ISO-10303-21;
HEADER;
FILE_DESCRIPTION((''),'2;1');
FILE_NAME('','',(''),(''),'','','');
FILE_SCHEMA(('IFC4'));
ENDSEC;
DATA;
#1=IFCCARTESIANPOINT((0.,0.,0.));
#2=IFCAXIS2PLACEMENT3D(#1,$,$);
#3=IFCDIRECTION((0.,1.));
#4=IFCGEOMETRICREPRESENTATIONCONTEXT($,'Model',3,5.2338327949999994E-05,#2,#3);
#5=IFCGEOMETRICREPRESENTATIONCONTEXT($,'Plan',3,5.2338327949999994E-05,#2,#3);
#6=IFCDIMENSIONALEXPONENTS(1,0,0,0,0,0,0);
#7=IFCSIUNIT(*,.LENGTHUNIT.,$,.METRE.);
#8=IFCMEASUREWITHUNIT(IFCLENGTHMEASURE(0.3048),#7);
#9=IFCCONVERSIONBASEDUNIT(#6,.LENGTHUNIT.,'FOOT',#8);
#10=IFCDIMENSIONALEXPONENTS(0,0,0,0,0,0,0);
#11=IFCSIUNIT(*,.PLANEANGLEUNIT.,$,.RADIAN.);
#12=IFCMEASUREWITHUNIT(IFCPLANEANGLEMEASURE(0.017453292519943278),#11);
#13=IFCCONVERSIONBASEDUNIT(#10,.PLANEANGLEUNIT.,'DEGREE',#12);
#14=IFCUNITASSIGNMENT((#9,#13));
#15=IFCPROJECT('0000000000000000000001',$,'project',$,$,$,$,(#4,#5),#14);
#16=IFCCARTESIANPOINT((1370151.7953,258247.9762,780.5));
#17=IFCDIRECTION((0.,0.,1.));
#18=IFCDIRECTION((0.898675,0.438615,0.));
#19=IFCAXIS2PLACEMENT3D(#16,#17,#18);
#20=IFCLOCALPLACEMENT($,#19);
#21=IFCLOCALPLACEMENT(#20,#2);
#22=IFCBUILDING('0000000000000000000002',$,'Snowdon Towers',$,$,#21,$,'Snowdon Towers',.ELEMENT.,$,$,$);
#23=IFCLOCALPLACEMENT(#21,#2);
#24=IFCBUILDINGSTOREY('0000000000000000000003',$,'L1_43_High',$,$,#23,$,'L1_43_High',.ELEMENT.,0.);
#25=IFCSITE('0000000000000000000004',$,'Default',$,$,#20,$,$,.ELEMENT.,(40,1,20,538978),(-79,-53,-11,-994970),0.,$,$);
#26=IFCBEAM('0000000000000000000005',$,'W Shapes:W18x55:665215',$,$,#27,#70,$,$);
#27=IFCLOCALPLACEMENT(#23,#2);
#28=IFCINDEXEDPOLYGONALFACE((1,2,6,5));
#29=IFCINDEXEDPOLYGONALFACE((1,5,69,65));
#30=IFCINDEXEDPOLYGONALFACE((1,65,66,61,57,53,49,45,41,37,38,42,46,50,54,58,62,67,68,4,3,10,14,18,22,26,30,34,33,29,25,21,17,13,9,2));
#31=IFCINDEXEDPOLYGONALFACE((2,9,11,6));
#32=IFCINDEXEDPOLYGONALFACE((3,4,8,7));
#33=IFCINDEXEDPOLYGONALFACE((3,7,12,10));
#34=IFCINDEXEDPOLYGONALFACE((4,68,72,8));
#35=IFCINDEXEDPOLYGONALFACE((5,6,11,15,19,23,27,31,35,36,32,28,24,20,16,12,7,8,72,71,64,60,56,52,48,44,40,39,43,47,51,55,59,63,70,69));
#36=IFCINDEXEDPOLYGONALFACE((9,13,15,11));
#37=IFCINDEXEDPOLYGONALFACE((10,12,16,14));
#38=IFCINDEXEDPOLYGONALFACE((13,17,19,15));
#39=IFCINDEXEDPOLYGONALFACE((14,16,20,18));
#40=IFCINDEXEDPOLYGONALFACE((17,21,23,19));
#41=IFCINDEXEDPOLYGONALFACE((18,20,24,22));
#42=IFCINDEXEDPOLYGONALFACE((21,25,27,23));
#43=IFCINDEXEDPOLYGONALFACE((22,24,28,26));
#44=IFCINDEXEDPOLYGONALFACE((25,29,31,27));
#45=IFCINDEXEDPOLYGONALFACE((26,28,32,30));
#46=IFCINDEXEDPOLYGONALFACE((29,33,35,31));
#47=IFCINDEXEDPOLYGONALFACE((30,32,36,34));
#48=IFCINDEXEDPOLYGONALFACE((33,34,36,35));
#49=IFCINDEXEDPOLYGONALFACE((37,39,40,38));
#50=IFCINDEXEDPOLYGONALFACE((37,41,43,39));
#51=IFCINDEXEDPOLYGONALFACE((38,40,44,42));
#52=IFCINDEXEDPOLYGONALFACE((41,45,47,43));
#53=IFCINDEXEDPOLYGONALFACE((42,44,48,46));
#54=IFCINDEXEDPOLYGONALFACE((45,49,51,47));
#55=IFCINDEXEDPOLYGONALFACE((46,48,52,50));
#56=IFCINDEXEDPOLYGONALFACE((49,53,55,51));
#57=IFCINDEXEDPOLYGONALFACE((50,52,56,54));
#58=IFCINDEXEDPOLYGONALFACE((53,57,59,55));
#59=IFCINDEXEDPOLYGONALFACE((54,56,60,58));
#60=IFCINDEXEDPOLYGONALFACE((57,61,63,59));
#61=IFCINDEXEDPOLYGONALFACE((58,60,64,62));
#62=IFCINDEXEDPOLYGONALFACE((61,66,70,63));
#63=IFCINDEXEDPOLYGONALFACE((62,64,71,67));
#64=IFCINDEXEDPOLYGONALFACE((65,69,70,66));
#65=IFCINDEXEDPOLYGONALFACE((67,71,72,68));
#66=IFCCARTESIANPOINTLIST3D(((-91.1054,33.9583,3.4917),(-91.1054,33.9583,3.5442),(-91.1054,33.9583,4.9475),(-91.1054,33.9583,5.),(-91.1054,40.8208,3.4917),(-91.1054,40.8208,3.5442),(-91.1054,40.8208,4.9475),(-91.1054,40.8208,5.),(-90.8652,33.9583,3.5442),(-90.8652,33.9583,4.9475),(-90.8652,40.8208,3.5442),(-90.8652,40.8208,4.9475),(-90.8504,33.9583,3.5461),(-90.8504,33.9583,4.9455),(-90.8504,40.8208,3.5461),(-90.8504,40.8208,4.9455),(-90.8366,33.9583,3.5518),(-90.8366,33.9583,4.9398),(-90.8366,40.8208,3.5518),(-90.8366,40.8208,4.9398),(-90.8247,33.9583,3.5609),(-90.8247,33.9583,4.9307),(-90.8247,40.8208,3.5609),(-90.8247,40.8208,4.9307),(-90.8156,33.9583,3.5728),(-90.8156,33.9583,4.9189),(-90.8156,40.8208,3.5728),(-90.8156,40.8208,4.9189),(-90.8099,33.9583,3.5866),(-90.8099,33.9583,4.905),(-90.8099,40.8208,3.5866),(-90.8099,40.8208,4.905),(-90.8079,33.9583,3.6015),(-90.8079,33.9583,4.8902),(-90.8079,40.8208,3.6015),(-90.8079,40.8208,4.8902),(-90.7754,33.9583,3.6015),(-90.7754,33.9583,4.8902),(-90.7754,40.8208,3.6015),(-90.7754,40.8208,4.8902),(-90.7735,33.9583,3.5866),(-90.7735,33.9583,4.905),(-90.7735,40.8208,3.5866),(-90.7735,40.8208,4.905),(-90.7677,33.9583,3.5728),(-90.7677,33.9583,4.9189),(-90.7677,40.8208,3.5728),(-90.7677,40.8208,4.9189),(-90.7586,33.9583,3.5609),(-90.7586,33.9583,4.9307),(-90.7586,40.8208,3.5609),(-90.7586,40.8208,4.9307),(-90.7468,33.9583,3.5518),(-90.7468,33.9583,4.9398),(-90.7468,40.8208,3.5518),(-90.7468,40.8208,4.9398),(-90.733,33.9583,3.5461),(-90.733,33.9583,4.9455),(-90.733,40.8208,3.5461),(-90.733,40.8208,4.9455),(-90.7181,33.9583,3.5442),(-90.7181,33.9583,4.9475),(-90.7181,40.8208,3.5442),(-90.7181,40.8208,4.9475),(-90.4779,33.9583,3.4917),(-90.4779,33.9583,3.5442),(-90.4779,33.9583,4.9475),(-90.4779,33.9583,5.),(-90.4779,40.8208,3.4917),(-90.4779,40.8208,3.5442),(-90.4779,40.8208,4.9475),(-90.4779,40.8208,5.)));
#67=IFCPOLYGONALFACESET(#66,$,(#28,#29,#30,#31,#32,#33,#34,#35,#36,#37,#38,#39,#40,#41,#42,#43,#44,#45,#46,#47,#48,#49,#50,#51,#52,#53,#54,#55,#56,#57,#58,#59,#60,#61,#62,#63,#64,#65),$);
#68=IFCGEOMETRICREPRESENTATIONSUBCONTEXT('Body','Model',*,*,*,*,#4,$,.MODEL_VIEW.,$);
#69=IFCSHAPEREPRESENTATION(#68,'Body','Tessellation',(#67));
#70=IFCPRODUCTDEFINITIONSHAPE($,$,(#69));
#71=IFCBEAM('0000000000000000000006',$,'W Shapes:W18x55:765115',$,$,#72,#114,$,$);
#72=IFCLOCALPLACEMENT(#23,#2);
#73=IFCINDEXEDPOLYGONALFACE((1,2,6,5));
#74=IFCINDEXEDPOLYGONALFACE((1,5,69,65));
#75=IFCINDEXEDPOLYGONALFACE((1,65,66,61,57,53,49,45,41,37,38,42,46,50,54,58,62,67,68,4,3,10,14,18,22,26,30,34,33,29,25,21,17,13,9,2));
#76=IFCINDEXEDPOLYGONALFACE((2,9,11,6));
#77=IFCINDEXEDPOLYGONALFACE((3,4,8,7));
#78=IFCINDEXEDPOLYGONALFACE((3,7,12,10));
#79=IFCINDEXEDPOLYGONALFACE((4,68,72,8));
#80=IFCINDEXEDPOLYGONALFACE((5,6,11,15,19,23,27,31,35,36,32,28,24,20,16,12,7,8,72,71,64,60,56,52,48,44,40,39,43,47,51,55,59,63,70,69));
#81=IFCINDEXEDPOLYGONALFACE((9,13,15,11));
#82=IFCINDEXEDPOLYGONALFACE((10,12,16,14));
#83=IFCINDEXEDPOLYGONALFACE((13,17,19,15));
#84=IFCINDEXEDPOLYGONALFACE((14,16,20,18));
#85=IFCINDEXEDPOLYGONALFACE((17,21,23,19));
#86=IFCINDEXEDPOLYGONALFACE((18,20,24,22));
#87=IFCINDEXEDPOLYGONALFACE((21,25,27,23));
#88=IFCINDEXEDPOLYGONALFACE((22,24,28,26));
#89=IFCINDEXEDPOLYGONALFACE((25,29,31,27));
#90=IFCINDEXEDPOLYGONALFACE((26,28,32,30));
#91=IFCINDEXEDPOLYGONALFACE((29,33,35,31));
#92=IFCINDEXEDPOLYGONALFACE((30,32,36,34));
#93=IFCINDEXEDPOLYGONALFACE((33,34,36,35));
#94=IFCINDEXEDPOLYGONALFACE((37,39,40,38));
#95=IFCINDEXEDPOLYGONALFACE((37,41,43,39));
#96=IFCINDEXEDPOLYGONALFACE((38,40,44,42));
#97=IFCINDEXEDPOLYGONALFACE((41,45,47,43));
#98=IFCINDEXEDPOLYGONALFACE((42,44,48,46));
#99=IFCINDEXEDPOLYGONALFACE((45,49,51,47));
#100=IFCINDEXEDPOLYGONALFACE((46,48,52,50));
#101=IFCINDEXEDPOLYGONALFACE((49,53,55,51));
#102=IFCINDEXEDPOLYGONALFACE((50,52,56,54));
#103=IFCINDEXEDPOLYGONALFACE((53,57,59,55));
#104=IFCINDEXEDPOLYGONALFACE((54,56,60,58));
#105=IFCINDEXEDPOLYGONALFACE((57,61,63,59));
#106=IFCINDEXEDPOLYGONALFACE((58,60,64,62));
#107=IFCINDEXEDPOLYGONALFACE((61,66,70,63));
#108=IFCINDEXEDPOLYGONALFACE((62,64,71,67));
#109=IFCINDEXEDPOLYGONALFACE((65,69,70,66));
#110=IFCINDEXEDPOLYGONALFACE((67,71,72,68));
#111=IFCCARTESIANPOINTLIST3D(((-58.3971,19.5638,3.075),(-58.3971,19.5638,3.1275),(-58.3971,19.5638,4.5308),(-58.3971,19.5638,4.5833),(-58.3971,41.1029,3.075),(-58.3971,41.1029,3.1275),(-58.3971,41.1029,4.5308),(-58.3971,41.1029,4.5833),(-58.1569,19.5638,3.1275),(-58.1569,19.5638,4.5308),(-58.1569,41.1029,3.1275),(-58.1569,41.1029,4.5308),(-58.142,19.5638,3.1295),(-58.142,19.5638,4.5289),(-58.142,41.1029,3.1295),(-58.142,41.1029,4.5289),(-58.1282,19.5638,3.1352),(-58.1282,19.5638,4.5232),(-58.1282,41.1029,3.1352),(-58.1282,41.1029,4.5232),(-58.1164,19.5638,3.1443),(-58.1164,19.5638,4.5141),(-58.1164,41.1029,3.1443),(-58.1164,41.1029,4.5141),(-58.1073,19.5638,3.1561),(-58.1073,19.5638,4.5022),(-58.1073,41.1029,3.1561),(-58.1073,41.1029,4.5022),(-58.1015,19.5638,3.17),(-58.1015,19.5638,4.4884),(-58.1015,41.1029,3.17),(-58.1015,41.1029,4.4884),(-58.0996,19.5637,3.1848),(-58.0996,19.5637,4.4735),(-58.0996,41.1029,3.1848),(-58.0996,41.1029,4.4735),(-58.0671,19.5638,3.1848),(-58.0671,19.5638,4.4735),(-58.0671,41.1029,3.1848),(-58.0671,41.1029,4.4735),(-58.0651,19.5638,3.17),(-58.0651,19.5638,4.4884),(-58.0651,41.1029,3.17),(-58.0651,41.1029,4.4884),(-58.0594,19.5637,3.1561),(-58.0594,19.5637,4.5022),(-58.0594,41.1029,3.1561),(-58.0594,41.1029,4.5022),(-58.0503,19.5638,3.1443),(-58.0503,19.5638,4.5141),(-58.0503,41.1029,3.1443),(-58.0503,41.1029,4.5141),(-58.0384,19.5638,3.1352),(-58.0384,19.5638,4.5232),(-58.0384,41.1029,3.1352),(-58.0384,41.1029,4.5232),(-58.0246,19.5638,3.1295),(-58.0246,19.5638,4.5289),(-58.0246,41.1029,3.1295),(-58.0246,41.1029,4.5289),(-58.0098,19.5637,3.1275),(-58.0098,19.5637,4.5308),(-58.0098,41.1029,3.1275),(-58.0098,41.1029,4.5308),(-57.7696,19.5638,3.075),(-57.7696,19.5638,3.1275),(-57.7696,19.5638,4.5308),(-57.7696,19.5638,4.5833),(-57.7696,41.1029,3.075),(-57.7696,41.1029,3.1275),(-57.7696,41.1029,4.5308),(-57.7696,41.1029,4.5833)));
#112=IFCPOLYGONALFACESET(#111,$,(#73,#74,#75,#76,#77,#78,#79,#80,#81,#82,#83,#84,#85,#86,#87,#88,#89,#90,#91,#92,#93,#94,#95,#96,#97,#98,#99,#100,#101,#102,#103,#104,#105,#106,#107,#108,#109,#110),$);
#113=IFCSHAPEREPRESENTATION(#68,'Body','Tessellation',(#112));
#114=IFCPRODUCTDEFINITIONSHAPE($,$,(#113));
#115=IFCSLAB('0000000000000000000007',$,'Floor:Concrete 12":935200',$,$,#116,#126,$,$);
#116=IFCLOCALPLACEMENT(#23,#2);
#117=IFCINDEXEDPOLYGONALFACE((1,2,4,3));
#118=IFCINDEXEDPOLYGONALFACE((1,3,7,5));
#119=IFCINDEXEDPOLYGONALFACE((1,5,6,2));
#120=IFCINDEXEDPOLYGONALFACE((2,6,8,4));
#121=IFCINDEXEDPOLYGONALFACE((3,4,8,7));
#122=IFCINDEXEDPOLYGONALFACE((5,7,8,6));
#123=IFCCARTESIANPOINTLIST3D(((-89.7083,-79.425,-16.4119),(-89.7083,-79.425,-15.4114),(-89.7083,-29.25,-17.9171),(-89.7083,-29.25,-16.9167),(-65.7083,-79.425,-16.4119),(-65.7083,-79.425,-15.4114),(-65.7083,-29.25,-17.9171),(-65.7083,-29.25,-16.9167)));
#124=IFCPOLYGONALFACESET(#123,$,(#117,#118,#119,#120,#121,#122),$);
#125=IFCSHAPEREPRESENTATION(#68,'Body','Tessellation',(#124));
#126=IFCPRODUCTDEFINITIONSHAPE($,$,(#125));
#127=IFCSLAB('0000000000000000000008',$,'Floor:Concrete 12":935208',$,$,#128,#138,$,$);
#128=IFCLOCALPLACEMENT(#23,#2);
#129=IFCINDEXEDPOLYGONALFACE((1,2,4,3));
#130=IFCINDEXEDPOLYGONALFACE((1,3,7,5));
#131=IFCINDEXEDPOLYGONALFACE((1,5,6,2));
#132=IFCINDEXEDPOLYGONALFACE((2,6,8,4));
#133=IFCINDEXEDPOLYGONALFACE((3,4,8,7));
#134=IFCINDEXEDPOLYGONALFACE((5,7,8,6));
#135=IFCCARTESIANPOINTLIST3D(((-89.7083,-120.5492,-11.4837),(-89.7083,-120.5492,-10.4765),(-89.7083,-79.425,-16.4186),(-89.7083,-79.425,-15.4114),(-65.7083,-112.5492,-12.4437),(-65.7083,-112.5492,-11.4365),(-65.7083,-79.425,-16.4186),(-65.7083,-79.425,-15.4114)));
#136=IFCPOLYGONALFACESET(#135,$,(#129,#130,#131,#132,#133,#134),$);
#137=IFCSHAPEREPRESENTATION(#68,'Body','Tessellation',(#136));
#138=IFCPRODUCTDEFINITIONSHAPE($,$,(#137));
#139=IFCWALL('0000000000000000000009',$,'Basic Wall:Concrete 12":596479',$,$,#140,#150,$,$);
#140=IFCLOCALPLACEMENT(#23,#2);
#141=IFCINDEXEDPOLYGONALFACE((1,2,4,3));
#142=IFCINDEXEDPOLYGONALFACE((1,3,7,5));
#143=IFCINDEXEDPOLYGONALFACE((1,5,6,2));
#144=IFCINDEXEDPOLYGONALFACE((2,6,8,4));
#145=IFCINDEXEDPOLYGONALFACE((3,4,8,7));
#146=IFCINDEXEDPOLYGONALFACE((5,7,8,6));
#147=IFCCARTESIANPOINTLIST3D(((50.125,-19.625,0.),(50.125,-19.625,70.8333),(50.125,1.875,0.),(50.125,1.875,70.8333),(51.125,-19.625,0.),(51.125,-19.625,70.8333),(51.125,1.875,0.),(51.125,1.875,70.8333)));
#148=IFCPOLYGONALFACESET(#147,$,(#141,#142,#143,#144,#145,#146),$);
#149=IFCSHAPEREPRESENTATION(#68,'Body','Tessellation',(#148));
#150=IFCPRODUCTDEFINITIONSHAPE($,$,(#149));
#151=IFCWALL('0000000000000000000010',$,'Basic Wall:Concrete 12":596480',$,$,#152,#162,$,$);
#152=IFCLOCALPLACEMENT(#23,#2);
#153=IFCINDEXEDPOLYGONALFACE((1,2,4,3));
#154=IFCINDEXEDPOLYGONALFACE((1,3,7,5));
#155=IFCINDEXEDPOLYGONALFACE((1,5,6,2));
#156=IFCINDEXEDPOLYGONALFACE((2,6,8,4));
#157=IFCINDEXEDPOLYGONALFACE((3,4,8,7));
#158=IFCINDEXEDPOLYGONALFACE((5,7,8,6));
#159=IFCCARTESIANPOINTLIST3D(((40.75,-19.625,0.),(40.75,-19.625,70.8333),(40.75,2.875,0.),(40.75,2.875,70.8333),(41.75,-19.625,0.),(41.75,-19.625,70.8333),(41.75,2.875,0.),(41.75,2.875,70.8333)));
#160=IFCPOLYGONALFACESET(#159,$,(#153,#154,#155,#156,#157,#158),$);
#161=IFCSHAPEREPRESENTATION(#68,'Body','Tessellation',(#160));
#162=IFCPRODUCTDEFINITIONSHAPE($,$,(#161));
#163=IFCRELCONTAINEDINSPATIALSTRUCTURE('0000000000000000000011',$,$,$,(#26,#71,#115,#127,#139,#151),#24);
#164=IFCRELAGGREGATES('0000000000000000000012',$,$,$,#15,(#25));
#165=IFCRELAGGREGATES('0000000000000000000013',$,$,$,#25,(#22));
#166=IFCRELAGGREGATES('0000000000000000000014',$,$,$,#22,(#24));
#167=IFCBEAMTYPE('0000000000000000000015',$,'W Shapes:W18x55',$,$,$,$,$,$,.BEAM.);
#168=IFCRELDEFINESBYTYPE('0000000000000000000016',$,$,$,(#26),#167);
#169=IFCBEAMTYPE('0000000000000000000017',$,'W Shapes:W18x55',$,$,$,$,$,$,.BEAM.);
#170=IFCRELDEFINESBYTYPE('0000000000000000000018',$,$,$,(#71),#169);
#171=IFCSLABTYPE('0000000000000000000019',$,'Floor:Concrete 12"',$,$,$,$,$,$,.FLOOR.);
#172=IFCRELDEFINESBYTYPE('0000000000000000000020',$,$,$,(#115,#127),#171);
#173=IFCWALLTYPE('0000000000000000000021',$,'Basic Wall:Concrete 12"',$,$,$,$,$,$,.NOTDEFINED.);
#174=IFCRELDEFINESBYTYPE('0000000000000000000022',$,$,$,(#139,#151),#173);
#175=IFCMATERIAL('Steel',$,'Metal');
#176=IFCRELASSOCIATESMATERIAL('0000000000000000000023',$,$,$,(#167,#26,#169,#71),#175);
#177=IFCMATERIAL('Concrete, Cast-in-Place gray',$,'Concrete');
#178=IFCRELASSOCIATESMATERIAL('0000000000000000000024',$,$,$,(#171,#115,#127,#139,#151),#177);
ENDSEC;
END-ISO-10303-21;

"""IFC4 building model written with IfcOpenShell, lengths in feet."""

from ifc_helpers import new_model, entity, si_unit, converted_unit, direction, frame, frame_2d, origin, place, context, subcontext, project, spatial, polyline, line, arc, indexed_curve, rectangle, outline, extrude, source, transform, mapped, material, type_object, type_shapes, element, save


model = new_model("IFC4")

# Units and contexts
model_context = context("Model", 3, precision=5.2338327949999994e-05, world=origin(), true_north=direction((0.0, 1.0)))
plan_context = context("Plan", 3, precision=5.2338327949999994e-05, world=origin(), true_north=direction((0.0, 1.0)))
body_context = subcontext(model_context, "Body", "Model", "MODEL_VIEW")
ifc_project = project(units=[converted_unit("LENGTHUNIT", "FOOT", entity("IfcLengthMeasure", 0.3048), si_unit("LENGTHUNIT", "METRE"), dimensions=[1, 0, 0, 0, 0, 0, 0]), converted_unit("PLANEANGLEUNIT", "DEGREE", entity("IfcPlaneAngleMeasure", 0.017453292519943278), si_unit("PLANEANGLEUNIT", "RADIAN"), dimensions=[0, 0, 0, 0, 0, 0, 0])], contexts=[model_context, plan_context])

# Site, building, storey
site_placement = place(None, frame((1370151.7953, 258247.9762, 780.5), z_axis=(0.0, 0.0, 1.0), x_axis=(0.898675, 0.438615, 0.0)))
site = spatial("IfcSite", under=ifc_project, at=site_placement, Name="Default", CompositionType="ELEMENT", RefLatitude=(40, 1, 20, 538978), RefLongitude=(-79, -53, -11, -994970), RefElevation=0.0)
building_placement = place(site_placement, origin())
building = spatial("IfcBuilding", under=site, at=building_placement, Name="Snowdon Towers", LongName="Snowdon Towers", CompositionType="ELEMENT")
storey_placement = place(building_placement, origin())
storey = spatial("IfcBuildingStorey", under=building, at=storey_placement, Name="L1_43_High", LongName="L1_43_High", CompositionType="ELEMENT", Elevation=0.0)

# Shared definitions
ifc_material_1 = material(Name="Steel", Category="Metal")

# Beams
ifc_material_2 = material(Name="Concrete, Cast-in-Place gray", Category="Concrete")
beam_type_1 = type_object("IfcBeamType", Name="W Shapes:W18x55", PredefinedType="BEAM", material=ifc_material_1)
shared_shape_1 = source(origin(), body_context, "Body", "SweptSolid", [
    extrude(outline(indexed_curve([(-0.7542, -0.3138), (-0.7017, -0.3138), (-0.7017, -0.0735), (-0.6849, -0.033), (-0.6444, -0.0162), (0.6444, -0.0162), (0.6849, -0.033), (0.7017, -0.0735), (0.7017, -0.3138), (0.7542, -0.3138), (0.7542, 0.3138), (0.7017, 0.3138), (0.7017, 0.0735), (0.6849, 0.033), (0.6444, 0.0163), (-0.6444, 0.0163), (-0.6849, 0.033), (-0.7017, 0.0735), (-0.7017, 0.3137), (-0.7542, 0.3137)], segments=[line(1, 2, 3), arc(3, 4, 5), line(5, 6), arc(6, 7, 8), line(8, 9, 10, 11, 12, 13), arc(13, 14, 15), line(15, 16), arc(16, 17, 18), line(18, 19, 20, 1)], self_intersect=False)), frame((-3.1125, 0.0, 0.0), z_axis=(1.0, 0.0, 0.0), x_axis=(0.0, 0.0, -1.0)), (0.0, 0.0, 1.0), 6.8625),
])
type_shapes(beam_type_1, [shared_shape_1])
beam_1_placement = place(storey_placement, frame((-90.7917, 37.7083, 4.2458), z_axis=(0.0, 0.0, 1.0), x_axis=(0.0, -1.0, 0.0)))
element("IfcBeam", 1, at=beam_1_placement, inside=storey, type_object=beam_type_1, material=ifc_material_1, Name="W Shapes:W18x55:665215", context=body_context, shape_type="MappedRepresentation", body=[
    mapped(shared_shape_1, transform((0.0, 0.0, 0.0), scale=1.0)),
])
beam_type_2 = type_object("IfcBeamType", Name="W Shapes:W18x55", PredefinedType="BEAM", material=ifc_material_1)
shared_shape_2 = source(origin(), body_context, "Body", "SweptSolid", [
    extrude(outline(indexed_curve([(-0.7542, -0.3138), (-0.7017, -0.3138), (-0.7017, -0.0735), (-0.6849, -0.033), (-0.6444, -0.0162), (0.6444, -0.0162), (0.6849, -0.033), (0.7017, -0.0735), (0.7017, -0.3138), (0.7542, -0.3138), (0.7542, 0.3138), (0.7017, 0.3138), (0.7017, 0.0735), (0.6849, 0.033), (0.6444, 0.0163), (-0.6444, 0.0163), (-0.6849, 0.033), (-0.7017, 0.0735), (-0.7017, 0.3137), (-0.7542, 0.3137)], segments=[line(1, 2, 3), arc(3, 4, 5), line(5, 6), arc(6, 7, 8), line(8, 9, 10, 11, 12, 13), arc(13, 14, 15), line(15, 16), arc(16, 17, 18), line(18, 19, 20, 1)], self_intersect=False)), frame((-10.7696, 0.0, 0.0), z_axis=(1.0, 0.0, 0.0), x_axis=(0.0, 0.0, -1.0)), (0.0, 0.0, 1.0), 21.5392),
])
type_shapes(beam_type_2, [shared_shape_2])
beam_2_placement = place(storey_placement, frame((-58.0833, 30.3333, 3.8292), z_axis=(0.0, 0.0, 1.0), x_axis=(0.0, 1.0, 0.0)))
element("IfcBeam", 2, at=beam_2_placement, inside=storey, type_object=beam_type_2, material=ifc_material_1, Name="W Shapes:W18x55:765115", context=body_context, shape_type="MappedRepresentation", body=[
    mapped(shared_shape_2, transform((0.0, 0.0, 0.0), scale=1.0)),
])

# Slabs
slab_type_1 = type_object("IfcSlabType", Name="Floor:Concrete 12\"", PredefinedType="FLOOR", material=ifc_material_2)
slab_1_placement = place(storey_placement, frame((-89.7083, -79.425, -17.9171)))
element("IfcSlab", 3, at=slab_1_placement, inside=storey, type_object=slab_type_1, material=ifc_material_2, Name="Floor:Concrete 12\":935200", context=body_context, shape_type="SweptSolid", body=[
    extrude(rectangle(XDim=24.0, YDim=50.1976, at=frame_2d((0.0, -25.0988), x_axis=(1.0, 0.0))), frame((12.0, 50.175, 1.0004), z_axis=(0.0, 0.029987, 0.99955), x_axis=(1.0, 0.0, 0.0)), (0.0, 0.029987, -0.99955), 1.0004),
])
slab_2_placement = place(storey_placement, frame((-89.7083, -120.5492, -16.4186)))
element("IfcSlab", 4, at=slab_2_placement, inside=storey, type_object=slab_type_1, material=ifc_material_2, Name="Floor:Concrete 12\":935208", context=body_context, shape_type="SweptSolid", body=[
    extrude(outline(polyline([(-12.0, -41.4193), (12.0, -33.3619), (12.0, 0.0), (-12.0, 0.0), (-12.0, -41.4193)])), frame((12.0, 41.1242, 1.0072), z_axis=(0.0, 0.119145, 0.992877), x_axis=(1.0, 0.0, 0.0)), (0.0, 0.119145, -0.992877), 1.0072),
])

# Walls
wall_type = type_object("IfcWallType", Name="Basic Wall:Concrete 12\"", PredefinedType="NOTDEFINED")
wall_1_placement = place(storey_placement, frame((50.625, -19.625, 0.0), z_axis=(0.0, 0.0, 1.0), x_axis=(0.0, 1.0, 0.0)))
element("IfcWall", 5, at=wall_1_placement, inside=storey, type_object=wall_type, material=ifc_material_2, Name="Basic Wall:Concrete 12\":596479", context=body_context, shape_type="SweptSolid", body=[
    extrude(outline(indexed_curve([(21.5, 0.5), (0.0, 0.5), (0.0, -0.5), (21.5, -0.5), (21.5, 0.5)], self_intersect=False)), origin(), (0.0, 0.0, 1.0), 70.8333),
])
wall_2_placement = place(storey_placement, frame((41.25, 2.875, 0.0), z_axis=(0.0, 0.0, 1.0), x_axis=(0.0, -1.0, 0.0)))
element("IfcWall", 6, at=wall_2_placement, inside=storey, type_object=wall_type, material=ifc_material_2, Name="Basic Wall:Concrete 12\":596480", context=body_context, shape_type="SweptSolid", body=[
    extrude(outline(indexed_curve([(22.5, 0.5), (0.0, 0.5), (0.0, -0.5), (22.5, -0.5), (22.5, 0.5)], self_intersect=False)), origin(), (0.0, 0.0, 1.0), 70.8333),
])

save(model, "model.ifc")
